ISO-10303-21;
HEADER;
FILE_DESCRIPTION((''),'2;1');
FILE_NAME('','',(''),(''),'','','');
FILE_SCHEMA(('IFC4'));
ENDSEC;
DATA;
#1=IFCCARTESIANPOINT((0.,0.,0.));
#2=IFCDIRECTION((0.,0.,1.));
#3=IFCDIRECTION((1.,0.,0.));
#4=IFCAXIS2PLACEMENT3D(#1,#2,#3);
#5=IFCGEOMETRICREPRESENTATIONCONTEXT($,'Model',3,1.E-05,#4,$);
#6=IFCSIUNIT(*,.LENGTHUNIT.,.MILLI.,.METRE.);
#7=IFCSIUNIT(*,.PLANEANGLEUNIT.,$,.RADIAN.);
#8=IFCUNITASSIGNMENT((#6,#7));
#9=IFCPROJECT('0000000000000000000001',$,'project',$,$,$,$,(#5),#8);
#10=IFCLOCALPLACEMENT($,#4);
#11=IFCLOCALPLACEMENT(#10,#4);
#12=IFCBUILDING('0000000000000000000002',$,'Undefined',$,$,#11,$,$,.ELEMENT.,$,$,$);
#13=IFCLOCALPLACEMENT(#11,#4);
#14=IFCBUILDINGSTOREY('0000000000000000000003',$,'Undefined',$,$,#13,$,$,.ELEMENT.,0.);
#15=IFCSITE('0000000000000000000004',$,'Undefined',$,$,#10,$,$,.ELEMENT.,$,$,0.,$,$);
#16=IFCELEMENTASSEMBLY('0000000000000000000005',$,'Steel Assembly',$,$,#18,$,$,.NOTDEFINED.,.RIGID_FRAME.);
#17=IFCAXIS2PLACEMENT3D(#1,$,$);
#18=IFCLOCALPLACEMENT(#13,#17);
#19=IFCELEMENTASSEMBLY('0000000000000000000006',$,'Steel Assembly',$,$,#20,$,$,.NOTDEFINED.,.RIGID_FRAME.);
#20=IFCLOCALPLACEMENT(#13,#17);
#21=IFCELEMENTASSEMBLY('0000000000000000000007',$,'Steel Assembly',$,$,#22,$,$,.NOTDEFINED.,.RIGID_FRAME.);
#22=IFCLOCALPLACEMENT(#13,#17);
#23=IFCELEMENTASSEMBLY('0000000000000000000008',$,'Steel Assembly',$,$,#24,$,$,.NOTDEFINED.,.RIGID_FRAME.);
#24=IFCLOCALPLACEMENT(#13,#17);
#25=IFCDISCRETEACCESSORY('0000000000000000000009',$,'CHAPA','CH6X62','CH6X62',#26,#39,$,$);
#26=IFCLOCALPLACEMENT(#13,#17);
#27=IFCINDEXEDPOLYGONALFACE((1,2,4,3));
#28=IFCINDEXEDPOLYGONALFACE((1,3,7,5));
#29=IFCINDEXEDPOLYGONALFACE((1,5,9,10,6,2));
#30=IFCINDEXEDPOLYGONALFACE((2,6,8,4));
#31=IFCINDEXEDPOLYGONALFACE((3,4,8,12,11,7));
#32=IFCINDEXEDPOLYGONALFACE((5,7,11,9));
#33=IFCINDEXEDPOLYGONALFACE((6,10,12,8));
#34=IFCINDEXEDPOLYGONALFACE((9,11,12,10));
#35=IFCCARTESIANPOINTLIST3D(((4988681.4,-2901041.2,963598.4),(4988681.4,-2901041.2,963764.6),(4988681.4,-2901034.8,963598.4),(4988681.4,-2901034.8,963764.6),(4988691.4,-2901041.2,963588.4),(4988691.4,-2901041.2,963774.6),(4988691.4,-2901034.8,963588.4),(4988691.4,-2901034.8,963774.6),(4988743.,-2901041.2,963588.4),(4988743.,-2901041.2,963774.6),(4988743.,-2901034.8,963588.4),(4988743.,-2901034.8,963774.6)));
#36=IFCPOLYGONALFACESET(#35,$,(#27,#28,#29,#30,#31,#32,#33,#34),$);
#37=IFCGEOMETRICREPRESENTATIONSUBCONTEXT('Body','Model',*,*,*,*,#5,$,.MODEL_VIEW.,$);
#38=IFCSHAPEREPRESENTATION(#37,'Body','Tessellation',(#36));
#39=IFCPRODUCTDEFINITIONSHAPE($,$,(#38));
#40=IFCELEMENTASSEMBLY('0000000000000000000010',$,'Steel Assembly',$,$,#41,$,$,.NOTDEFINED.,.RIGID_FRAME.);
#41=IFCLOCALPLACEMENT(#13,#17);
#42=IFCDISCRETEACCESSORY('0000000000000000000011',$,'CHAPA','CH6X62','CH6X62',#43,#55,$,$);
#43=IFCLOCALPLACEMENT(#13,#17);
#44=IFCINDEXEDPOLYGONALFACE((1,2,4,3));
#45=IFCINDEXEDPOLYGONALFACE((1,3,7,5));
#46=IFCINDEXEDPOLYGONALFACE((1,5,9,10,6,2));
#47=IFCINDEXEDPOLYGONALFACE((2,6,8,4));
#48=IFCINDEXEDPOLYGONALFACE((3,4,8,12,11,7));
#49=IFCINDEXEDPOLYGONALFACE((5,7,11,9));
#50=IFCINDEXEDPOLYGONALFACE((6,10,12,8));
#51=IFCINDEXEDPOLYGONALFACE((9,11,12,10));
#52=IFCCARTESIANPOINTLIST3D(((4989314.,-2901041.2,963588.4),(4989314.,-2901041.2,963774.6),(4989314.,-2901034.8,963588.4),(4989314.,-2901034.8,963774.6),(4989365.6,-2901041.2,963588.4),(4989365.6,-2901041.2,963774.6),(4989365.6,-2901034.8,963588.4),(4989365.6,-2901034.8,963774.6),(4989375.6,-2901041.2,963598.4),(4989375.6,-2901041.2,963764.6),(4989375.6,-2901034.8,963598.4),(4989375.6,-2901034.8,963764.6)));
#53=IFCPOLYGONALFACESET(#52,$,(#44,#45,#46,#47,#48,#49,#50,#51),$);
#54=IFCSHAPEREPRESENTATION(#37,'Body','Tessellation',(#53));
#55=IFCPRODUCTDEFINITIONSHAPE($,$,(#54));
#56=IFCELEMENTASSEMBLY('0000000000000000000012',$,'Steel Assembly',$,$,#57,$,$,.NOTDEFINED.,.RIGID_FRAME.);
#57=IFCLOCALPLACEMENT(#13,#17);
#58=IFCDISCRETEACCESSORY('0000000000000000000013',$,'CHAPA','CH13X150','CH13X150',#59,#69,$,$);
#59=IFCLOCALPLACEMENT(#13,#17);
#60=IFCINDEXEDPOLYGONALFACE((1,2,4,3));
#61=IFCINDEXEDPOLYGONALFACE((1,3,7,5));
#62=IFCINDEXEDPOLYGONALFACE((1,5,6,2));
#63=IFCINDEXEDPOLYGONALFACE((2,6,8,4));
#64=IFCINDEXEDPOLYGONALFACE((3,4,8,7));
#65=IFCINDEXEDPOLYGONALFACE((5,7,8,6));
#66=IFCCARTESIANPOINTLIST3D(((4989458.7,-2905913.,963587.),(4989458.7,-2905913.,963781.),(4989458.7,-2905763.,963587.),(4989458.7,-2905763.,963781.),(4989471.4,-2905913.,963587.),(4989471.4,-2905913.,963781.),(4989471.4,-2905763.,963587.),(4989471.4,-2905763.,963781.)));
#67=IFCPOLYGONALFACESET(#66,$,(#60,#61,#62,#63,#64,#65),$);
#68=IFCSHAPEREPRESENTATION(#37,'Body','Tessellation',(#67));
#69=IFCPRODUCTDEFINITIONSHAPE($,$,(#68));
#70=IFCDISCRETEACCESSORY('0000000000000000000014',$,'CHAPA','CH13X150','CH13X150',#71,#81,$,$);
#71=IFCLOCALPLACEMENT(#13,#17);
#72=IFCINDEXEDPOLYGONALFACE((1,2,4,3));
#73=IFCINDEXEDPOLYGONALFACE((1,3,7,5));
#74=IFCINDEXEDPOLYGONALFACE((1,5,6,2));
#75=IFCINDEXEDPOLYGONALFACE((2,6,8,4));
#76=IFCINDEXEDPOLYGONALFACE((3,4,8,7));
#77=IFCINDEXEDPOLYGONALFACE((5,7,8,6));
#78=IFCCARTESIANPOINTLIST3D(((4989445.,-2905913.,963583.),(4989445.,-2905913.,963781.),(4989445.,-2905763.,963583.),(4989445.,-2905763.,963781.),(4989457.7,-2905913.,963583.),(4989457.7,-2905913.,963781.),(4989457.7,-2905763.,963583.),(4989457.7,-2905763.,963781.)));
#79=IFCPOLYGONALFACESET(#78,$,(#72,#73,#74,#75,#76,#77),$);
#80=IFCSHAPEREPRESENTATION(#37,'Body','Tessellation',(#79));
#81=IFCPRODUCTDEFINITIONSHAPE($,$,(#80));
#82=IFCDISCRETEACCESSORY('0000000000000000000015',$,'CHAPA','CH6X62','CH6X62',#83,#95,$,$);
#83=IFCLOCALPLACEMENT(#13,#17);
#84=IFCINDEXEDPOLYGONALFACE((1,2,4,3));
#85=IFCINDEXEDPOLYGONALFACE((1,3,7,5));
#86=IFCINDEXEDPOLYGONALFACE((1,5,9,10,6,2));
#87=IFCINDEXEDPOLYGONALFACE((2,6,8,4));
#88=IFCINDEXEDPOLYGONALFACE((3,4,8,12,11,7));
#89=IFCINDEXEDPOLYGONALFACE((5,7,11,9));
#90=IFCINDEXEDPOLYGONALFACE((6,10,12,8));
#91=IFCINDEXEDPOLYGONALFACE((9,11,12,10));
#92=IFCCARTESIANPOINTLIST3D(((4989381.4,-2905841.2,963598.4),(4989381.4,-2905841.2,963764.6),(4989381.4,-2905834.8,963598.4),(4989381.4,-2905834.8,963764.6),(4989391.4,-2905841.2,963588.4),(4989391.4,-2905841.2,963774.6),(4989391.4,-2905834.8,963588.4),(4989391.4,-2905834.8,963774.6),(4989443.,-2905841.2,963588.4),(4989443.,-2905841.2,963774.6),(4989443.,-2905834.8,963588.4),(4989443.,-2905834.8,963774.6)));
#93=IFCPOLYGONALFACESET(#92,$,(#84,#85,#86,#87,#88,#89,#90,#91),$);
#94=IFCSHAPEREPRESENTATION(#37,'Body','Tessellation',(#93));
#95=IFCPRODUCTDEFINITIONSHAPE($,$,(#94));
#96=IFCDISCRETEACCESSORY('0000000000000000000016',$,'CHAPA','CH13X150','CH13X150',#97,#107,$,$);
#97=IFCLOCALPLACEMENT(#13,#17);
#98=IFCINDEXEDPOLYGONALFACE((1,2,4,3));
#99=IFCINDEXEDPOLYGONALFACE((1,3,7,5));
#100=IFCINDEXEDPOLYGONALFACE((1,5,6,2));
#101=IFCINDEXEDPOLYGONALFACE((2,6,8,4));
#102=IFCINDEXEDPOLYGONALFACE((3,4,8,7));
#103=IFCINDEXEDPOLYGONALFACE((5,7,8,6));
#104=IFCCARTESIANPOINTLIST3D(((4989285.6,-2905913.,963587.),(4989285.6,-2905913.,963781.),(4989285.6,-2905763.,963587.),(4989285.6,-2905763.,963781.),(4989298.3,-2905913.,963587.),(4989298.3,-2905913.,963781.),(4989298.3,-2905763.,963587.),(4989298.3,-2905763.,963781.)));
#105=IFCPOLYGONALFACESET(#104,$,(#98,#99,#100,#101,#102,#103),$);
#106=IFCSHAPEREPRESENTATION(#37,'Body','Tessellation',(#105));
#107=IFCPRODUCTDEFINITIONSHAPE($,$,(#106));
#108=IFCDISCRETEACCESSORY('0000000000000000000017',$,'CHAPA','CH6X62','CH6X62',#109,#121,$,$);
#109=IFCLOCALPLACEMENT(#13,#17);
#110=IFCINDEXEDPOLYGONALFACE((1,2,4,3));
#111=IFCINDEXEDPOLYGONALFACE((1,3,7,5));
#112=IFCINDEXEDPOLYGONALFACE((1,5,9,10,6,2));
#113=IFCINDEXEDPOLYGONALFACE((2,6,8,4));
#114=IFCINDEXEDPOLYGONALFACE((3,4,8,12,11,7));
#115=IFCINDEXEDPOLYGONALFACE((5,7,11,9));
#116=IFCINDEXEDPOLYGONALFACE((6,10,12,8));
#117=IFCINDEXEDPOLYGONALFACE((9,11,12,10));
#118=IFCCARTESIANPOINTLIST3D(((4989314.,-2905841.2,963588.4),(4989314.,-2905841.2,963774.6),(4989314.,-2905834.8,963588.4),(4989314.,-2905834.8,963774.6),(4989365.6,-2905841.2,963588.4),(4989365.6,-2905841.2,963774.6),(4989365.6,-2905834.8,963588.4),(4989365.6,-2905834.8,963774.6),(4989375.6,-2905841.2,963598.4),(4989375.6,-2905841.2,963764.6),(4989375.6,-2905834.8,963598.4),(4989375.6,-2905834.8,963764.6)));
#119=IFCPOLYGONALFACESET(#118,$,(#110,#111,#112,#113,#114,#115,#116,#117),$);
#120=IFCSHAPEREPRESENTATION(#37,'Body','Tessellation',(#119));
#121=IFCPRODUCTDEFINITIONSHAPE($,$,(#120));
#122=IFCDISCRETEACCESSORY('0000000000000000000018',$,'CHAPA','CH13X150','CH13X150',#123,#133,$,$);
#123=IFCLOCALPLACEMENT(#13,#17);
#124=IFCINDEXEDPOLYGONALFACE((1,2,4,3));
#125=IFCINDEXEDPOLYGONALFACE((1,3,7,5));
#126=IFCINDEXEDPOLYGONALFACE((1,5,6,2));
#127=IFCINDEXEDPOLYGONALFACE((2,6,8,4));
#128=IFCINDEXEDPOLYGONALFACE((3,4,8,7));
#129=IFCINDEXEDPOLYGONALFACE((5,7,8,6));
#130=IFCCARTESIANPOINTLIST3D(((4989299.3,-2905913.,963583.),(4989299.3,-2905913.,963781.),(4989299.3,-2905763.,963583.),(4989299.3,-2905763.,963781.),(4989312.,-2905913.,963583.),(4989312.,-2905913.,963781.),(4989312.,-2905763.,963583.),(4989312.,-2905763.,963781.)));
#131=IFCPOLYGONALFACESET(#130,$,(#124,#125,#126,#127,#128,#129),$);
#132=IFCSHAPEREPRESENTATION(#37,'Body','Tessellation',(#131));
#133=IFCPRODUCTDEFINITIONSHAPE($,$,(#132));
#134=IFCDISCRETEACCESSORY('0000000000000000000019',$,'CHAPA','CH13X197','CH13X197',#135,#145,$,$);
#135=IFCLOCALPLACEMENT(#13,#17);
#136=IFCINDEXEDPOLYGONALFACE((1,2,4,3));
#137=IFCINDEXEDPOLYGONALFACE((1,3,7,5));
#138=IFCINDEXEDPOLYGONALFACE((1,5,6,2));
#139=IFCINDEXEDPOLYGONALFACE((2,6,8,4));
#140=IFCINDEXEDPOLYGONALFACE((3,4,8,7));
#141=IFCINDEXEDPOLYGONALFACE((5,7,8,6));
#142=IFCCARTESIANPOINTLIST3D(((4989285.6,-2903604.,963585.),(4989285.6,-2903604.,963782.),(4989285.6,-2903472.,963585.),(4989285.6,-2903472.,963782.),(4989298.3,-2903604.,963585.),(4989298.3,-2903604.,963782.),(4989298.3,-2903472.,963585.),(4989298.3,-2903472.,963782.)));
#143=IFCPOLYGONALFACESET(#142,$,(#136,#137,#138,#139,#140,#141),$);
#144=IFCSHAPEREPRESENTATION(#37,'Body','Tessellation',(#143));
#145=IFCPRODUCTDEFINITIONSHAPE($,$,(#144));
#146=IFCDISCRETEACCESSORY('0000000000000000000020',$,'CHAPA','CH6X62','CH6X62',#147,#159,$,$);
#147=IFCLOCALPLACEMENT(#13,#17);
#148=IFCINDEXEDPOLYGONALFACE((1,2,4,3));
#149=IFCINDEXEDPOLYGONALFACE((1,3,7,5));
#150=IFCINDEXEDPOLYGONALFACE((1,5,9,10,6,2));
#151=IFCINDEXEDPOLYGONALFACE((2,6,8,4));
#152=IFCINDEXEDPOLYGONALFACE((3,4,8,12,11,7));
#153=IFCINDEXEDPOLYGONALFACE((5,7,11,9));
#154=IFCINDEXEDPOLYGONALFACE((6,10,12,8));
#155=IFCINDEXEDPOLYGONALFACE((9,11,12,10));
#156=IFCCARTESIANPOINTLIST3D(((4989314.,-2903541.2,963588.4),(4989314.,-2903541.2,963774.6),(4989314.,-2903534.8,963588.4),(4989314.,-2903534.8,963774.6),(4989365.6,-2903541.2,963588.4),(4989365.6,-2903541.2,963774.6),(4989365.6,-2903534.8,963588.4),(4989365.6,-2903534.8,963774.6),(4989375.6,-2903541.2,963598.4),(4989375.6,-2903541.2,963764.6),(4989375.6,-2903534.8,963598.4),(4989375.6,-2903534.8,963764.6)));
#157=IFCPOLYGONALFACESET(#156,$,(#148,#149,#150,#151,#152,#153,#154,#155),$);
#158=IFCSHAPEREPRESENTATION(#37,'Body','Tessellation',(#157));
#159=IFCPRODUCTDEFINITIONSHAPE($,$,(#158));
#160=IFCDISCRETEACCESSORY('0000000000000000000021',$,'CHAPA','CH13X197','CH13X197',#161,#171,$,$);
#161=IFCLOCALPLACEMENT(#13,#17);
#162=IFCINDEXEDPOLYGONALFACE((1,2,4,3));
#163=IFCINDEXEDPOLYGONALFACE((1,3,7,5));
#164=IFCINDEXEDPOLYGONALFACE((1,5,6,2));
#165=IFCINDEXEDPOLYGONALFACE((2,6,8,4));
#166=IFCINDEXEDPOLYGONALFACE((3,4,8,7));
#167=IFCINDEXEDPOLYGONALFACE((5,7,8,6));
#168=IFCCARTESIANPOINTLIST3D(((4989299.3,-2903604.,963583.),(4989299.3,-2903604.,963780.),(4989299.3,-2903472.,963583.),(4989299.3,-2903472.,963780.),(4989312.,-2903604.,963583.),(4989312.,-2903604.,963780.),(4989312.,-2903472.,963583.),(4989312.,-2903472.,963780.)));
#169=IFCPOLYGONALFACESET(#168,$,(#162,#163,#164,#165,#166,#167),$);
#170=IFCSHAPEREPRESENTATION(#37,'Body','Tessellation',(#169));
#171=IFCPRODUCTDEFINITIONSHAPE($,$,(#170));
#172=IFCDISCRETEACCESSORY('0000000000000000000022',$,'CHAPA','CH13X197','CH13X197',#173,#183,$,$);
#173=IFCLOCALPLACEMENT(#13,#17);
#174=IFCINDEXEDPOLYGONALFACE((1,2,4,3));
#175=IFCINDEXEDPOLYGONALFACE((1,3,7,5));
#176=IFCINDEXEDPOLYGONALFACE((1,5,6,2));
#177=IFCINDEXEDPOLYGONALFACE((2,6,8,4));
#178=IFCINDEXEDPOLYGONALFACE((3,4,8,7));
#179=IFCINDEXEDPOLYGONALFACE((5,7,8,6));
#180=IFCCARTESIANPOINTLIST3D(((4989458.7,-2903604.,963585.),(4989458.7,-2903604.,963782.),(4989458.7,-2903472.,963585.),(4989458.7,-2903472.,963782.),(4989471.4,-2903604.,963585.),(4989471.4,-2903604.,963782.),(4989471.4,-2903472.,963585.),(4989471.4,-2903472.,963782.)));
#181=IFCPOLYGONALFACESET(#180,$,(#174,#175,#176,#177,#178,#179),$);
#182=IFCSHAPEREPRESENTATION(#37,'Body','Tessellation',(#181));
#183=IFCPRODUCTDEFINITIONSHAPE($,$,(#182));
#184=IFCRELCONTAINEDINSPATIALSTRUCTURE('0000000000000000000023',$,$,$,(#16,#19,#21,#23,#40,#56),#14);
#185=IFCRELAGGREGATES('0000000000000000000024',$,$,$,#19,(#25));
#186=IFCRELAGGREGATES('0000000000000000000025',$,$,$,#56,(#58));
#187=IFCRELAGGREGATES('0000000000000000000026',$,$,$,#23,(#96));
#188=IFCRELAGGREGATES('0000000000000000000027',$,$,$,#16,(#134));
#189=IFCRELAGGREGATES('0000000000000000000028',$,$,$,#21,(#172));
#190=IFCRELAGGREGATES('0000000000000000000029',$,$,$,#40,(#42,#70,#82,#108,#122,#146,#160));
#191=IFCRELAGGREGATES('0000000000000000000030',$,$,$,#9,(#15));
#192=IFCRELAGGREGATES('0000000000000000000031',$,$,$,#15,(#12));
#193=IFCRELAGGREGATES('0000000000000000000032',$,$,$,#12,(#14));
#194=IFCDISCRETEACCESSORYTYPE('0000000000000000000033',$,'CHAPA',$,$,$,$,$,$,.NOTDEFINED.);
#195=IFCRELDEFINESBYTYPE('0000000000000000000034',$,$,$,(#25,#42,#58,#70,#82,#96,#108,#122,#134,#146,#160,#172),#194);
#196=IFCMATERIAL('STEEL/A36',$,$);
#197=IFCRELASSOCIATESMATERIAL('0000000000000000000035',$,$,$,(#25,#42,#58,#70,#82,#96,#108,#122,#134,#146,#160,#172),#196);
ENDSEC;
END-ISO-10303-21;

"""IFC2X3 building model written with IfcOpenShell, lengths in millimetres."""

from ifc_helpers import new_model, si_unit, frame, origin_with_axes, place, context, subcontext, project, spatial, polyline, outline, extrude, material, type_object, element, aggregate, save


model = new_model("IFC2X3")

# Units and contexts
model_context = context("Model", 3, precision=1e-05, world=origin_with_axes())
body_context = subcontext(model_context, "Body", "Model", "MODEL_VIEW")
ifc_project = project(units=[si_unit("LENGTHUNIT", "METRE", prefix="MILLI"), si_unit("PLANEANGLEUNIT", "RADIAN")], contexts=[model_context])

# Site, building, storey
site_placement = place(None, origin_with_axes())
site = spatial("IfcSite", under=ifc_project, at=site_placement, Name="Undefined", CompositionType="ELEMENT", RefElevation=0.0)
building_placement = place(site_placement, origin_with_axes())
building = spatial("IfcBuilding", under=site, at=building_placement, Name="Undefined", CompositionType="ELEMENT")
storey_placement = place(building_placement, origin_with_axes())
storey = spatial("IfcBuildingStorey", under=building, at=storey_placement, Name="Undefined", CompositionType="ELEMENT", Elevation=0.0)

# Element assembly
assembly_1_placement = place(storey_placement, origin_with_axes())
assembly_1 = element("IfcElementAssembly", 1, at=assembly_1_placement, inside=storey, Name="Steel Assembly", AssemblyPlace="NOTDEFINED", PredefinedType="RIGID_FRAME")
ifc_material = material(Name="STEEL/A36")
discrete_accessory_type = type_object("IfcDiscreteAccessoryType", Name="CHAPA")

# Element assembly
assembly_2_placement = place(storey_placement, origin_with_axes())
assembly_2 = element("IfcElementAssembly", 2, at=assembly_2_placement, inside=storey, Name="Steel Assembly", AssemblyPlace="NOTDEFINED", PredefinedType="RIGID_FRAME")

# Element assembly
assembly_3_placement = place(storey_placement, origin_with_axes())
assembly_3 = element("IfcElementAssembly", 3, at=assembly_3_placement, inside=storey, Name="Steel Assembly", AssemblyPlace="NOTDEFINED", PredefinedType="RIGID_FRAME")

# Element assembly
assembly_4_placement = place(storey_placement, origin_with_axes())
assembly_4 = element("IfcElementAssembly", 4, at=assembly_4_placement, inside=storey, Name="Steel Assembly", AssemblyPlace="NOTDEFINED", PredefinedType="RIGID_FRAME")

# Discrete accessory
discrete_accessory_1_placement = place(assembly_2_placement, frame((4988681.4, -2901038.0, 963774.6), z_axis=(0.0, 1.0, 0.0), x_axis=(1.0, 0.0, 0.0)))
discrete_accessory_1 = element("IfcDiscreteAccessory", 5, at=discrete_accessory_1_placement, type_object=discrete_accessory_type, material=ifc_material, Name="CHAPA", Description="CH6X62", ObjectType="CH6X62", context=body_context, shape_type="SweptSolid", body=[
    extrude(outline(polyline([(0.0, 10.0), (10.0, 0.0), (61.6, 0.0), (61.6, 186.2), (10.0, 186.2), (0.0, 176.2), (0.0, 10.0)])), frame((0.0, 0.0, -3.2), z_axis=(0.0, 0.0, 1.0), x_axis=(1.0, 0.0, 0.0)), (0.0, 0.0, 1.0), 6.4),
])
aggregate(assembly_2, [discrete_accessory_1])

# Element assemblies, discrete accessories
assembly_5_placement = place(storey_placement, origin_with_axes())
assembly_5 = element("IfcElementAssembly", 6, at=assembly_5_placement, inside=storey, Name="Steel Assembly", AssemblyPlace="NOTDEFINED", PredefinedType="RIGID_FRAME")
discrete_accessory_2_placement = place(assembly_5_placement, frame((4989375.6, -2901038.0, 963774.6), z_axis=(0.0, -1.0, 0.0), x_axis=(-1.0, 0.0, 0.0)))
discrete_accessory_2 = element("IfcDiscreteAccessory", 7, at=discrete_accessory_2_placement, type_object=discrete_accessory_type, material=ifc_material, Name="CHAPA", Description="CH6X62", ObjectType="CH6X62", context=body_context, shape_type="SweptSolid", body=[
    extrude(outline(polyline([(0.0, 10.0), (10.0, 0.0), (61.6, 0.0), (61.6, 186.2), (10.0, 186.2), (0.0, 176.2), (0.0, 10.0)])), frame((0.0, 0.0, -3.2), z_axis=(0.0, 0.0, 1.0), x_axis=(1.0, 0.0, 0.0)), (0.0, 0.0, 1.0), 6.4),
])
assembly_6_placement = place(storey_placement, origin_with_axes())
assembly_6 = element("IfcElementAssembly", 8, at=assembly_6_placement, inside=storey, Name="Steel Assembly", AssemblyPlace="NOTDEFINED", PredefinedType="RIGID_FRAME")
discrete_accessory_3_placement = place(assembly_6_placement, frame((4989465.0, -2905838.0, 963781.0), z_axis=(1.0, 0.0, 0.0), x_axis=(0.0, 0.0, -1.0)))
discrete_accessory_3 = element("IfcDiscreteAccessory", 9, at=discrete_accessory_3_placement, type_object=discrete_accessory_type, material=ifc_material, Name="CHAPA", Description="CH13X150", ObjectType="CH13X150", context=body_context, shape_type="SweptSolid", body=[
    extrude(outline(polyline([(194.0, -75.0), (0.0, -75.0), (0.0, 75.0), (194.0, 75.0), (194.0, -75.0)])), frame((0.0, 0.0, -6.3), z_axis=(0.0, 0.0, 1.0), x_axis=(1.0, 0.0, 0.0)), (0.0, 0.0, 1.0), 12.7),
])
aggregate(assembly_6, [discrete_accessory_3])

# Discrete accessories
discrete_accessory_4_placement = place(assembly_5_placement, frame((4989451.3, -2905838.0, 963781.0), z_axis=(1.0, 0.0, 0.0), x_axis=(0.0, 0.0, -1.0)))
discrete_accessory_4 = element("IfcDiscreteAccessory", 10, at=discrete_accessory_4_placement, type_object=discrete_accessory_type, material=ifc_material, Name="CHAPA", Description="CH13X150", ObjectType="CH13X150", context=body_context, shape_type="SweptSolid", body=[
    extrude(outline(polyline([(198.0, -75.0), (0.0, -75.0), (0.0, 75.0), (198.0, 75.0), (198.0, -75.0)])), frame((0.0, 0.0, -6.3), z_axis=(0.0, 0.0, 1.0), x_axis=(1.0, 0.0, 0.0)), (0.0, 0.0, 1.0), 12.7),
])
discrete_accessory_5_placement = place(assembly_5_placement, frame((4989381.4, -2905838.0, 963774.6), z_axis=(0.0, 1.0, 0.0), x_axis=(1.0, 0.0, 0.0)))
discrete_accessory_5 = element("IfcDiscreteAccessory", 11, at=discrete_accessory_5_placement, type_object=discrete_accessory_type, material=ifc_material, Name="CHAPA", Description="CH6X62", ObjectType="CH6X62", context=body_context, shape_type="SweptSolid", body=[
    extrude(outline(polyline([(0.0, 10.0), (10.0, 0.0), (61.6, 0.0), (61.6, 186.2), (10.0, 186.2), (0.0, 176.2), (0.0, 10.0)])), frame((0.0, 0.0, -3.2), z_axis=(0.0, 0.0, 1.0), x_axis=(1.0, 0.0, 0.0)), (0.0, 0.0, 1.0), 6.4),
])
discrete_accessory_6_placement = place(assembly_4_placement, frame((4989291.9, -2905838.0, 963781.0), z_axis=(-1.0, 0.0, 0.0), x_axis=(0.0, 0.0, -1.0)))
discrete_accessory_6 = element("IfcDiscreteAccessory", 12, at=discrete_accessory_6_placement, type_object=discrete_accessory_type, material=ifc_material, Name="CHAPA", Description="CH13X150", ObjectType="CH13X150", context=body_context, shape_type="SweptSolid", body=[
    extrude(outline(polyline([(194.0, 75.0), (194.0, -75.0), (0.0, -75.0), (0.0, 75.0), (194.0, 75.0)])), frame((0.0, 0.0, -6.3), z_axis=(0.0, 0.0, 1.0), x_axis=(1.0, 0.0, 0.0)), (0.0, 0.0, 1.0), 12.7),
])
aggregate(assembly_4, [discrete_accessory_6])
discrete_accessory_7_placement = place(assembly_5_placement, frame((4989375.6, -2905838.0, 963774.6), z_axis=(0.0, -1.0, 0.0), x_axis=(-1.0, 0.0, 0.0)))
discrete_accessory_7 = element("IfcDiscreteAccessory", 13, at=discrete_accessory_7_placement, type_object=discrete_accessory_type, material=ifc_material, Name="CHAPA", Description="CH6X62", ObjectType="CH6X62", context=body_context, shape_type="SweptSolid", body=[
    extrude(outline(polyline([(0.0, 10.0), (10.0, 0.0), (61.6, 0.0), (61.6, 186.2), (10.0, 186.2), (0.0, 176.2), (0.0, 10.0)])), frame((0.0, 0.0, -3.2), z_axis=(0.0, 0.0, 1.0), x_axis=(1.0, 0.0, 0.0)), (0.0, 0.0, 1.0), 6.4),
])
discrete_accessory_8_placement = place(assembly_5_placement, frame((4989305.6, -2905838.0, 963781.0), z_axis=(-1.0, 0.0, 0.0), x_axis=(0.0, 0.0, -1.0)))
discrete_accessory_8 = element("IfcDiscreteAccessory", 14, at=discrete_accessory_8_placement, type_object=discrete_accessory_type, material=ifc_material, Name="CHAPA", Description="CH13X150", ObjectType="CH13X150", context=body_context, shape_type="SweptSolid", body=[
    extrude(outline(polyline([(198.0, 75.0), (198.0, -75.0), (0.0, -75.0), (0.0, 75.0), (198.0, 75.0)])), frame((0.0, 0.0, -6.3), z_axis=(0.0, 0.0, 1.0), x_axis=(1.0, 0.0, 0.0)), (0.0, 0.0, 1.0), 12.7),
])
discrete_accessory_9_placement = place(assembly_1_placement, frame((4989291.9, -2903538.0, 963782.0), z_axis=(-1.0, 0.0, 0.0), x_axis=(0.0, 0.0, -1.0)))
discrete_accessory_9 = element("IfcDiscreteAccessory", 15, at=discrete_accessory_9_placement, type_object=discrete_accessory_type, material=ifc_material, Name="CHAPA", Description="CH13X197", ObjectType="CH13X197", context=body_context, shape_type="SweptSolid", body=[
    extrude(outline(polyline([(197.0, 66.0), (197.0, -66.0), (0.0, -66.0), (0.0, 66.0), (197.0, 66.0)])), frame((0.0, 0.0, -6.3), z_axis=(0.0, 0.0, 1.0), x_axis=(1.0, 0.0, 0.0)), (0.0, 0.0, 1.0), 12.7),
])
aggregate(assembly_1, [discrete_accessory_9])
discrete_accessory_10_placement = place(assembly_5_placement, frame((4989375.6, -2903538.0, 963774.6), z_axis=(0.0, -1.0, 0.0), x_axis=(-1.0, 0.0, 0.0)))
discrete_accessory_10 = element("IfcDiscreteAccessory", 16, at=discrete_accessory_10_placement, type_object=discrete_accessory_type, material=ifc_material, Name="CHAPA", Description="CH6X62", ObjectType="CH6X62", context=body_context, shape_type="SweptSolid", body=[
    extrude(outline(polyline([(0.0, 10.0), (10.0, 0.0), (61.6, 0.0), (61.6, 186.2), (10.0, 186.2), (0.0, 176.2), (0.0, 10.0)])), frame((0.0, 0.0, -3.2), z_axis=(0.0, 0.0, 1.0), x_axis=(1.0, 0.0, 0.0)), (0.0, 0.0, 1.0), 6.4),
])
discrete_accessory_11_placement = place(assembly_5_placement, frame((4989305.6, -2903538.0, 963780.0), z_axis=(-1.0, 0.0, 0.0), x_axis=(0.0, 0.0, -1.0)))
discrete_accessory_11 = element("IfcDiscreteAccessory", 17, at=discrete_accessory_11_placement, type_object=discrete_accessory_type, material=ifc_material, Name="CHAPA", Description="CH13X197", ObjectType="CH13X197", context=body_context, shape_type="SweptSolid", body=[
    extrude(outline(polyline([(197.0, 66.0), (197.0, -66.0), (0.0, -66.0), (0.0, 66.0), (197.0, 66.0)])), frame((0.0, 0.0, -6.3), z_axis=(0.0, 0.0, 1.0), x_axis=(1.0, 0.0, 0.0)), (0.0, 0.0, 1.0), 12.7),
])
discrete_accessory_12_placement = place(assembly_3_placement, frame((4989465.0, -2903538.0, 963782.0), z_axis=(1.0, 0.0, 0.0), x_axis=(0.0, 0.0, -1.0)))
discrete_accessory_12 = element("IfcDiscreteAccessory", 18, at=discrete_accessory_12_placement, type_object=discrete_accessory_type, material=ifc_material, Name="CHAPA", Description="CH13X197", ObjectType="CH13X197", context=body_context, shape_type="SweptSolid", body=[
    extrude(outline(polyline([(197.0, -66.0), (0.0, -66.0), (0.0, 66.0), (197.0, 66.0), (197.0, -66.0)])), frame((0.0, 0.0, -6.3), z_axis=(0.0, 0.0, 1.0), x_axis=(1.0, 0.0, 0.0)), (0.0, 0.0, 1.0), 12.7),
])
aggregate(assembly_3, [discrete_accessory_12])
aggregate(assembly_5, [discrete_accessory_2, discrete_accessory_4, discrete_accessory_5, discrete_accessory_7, discrete_accessory_8, discrete_accessory_10, discrete_accessory_11])

save(model, "model.ifc")
